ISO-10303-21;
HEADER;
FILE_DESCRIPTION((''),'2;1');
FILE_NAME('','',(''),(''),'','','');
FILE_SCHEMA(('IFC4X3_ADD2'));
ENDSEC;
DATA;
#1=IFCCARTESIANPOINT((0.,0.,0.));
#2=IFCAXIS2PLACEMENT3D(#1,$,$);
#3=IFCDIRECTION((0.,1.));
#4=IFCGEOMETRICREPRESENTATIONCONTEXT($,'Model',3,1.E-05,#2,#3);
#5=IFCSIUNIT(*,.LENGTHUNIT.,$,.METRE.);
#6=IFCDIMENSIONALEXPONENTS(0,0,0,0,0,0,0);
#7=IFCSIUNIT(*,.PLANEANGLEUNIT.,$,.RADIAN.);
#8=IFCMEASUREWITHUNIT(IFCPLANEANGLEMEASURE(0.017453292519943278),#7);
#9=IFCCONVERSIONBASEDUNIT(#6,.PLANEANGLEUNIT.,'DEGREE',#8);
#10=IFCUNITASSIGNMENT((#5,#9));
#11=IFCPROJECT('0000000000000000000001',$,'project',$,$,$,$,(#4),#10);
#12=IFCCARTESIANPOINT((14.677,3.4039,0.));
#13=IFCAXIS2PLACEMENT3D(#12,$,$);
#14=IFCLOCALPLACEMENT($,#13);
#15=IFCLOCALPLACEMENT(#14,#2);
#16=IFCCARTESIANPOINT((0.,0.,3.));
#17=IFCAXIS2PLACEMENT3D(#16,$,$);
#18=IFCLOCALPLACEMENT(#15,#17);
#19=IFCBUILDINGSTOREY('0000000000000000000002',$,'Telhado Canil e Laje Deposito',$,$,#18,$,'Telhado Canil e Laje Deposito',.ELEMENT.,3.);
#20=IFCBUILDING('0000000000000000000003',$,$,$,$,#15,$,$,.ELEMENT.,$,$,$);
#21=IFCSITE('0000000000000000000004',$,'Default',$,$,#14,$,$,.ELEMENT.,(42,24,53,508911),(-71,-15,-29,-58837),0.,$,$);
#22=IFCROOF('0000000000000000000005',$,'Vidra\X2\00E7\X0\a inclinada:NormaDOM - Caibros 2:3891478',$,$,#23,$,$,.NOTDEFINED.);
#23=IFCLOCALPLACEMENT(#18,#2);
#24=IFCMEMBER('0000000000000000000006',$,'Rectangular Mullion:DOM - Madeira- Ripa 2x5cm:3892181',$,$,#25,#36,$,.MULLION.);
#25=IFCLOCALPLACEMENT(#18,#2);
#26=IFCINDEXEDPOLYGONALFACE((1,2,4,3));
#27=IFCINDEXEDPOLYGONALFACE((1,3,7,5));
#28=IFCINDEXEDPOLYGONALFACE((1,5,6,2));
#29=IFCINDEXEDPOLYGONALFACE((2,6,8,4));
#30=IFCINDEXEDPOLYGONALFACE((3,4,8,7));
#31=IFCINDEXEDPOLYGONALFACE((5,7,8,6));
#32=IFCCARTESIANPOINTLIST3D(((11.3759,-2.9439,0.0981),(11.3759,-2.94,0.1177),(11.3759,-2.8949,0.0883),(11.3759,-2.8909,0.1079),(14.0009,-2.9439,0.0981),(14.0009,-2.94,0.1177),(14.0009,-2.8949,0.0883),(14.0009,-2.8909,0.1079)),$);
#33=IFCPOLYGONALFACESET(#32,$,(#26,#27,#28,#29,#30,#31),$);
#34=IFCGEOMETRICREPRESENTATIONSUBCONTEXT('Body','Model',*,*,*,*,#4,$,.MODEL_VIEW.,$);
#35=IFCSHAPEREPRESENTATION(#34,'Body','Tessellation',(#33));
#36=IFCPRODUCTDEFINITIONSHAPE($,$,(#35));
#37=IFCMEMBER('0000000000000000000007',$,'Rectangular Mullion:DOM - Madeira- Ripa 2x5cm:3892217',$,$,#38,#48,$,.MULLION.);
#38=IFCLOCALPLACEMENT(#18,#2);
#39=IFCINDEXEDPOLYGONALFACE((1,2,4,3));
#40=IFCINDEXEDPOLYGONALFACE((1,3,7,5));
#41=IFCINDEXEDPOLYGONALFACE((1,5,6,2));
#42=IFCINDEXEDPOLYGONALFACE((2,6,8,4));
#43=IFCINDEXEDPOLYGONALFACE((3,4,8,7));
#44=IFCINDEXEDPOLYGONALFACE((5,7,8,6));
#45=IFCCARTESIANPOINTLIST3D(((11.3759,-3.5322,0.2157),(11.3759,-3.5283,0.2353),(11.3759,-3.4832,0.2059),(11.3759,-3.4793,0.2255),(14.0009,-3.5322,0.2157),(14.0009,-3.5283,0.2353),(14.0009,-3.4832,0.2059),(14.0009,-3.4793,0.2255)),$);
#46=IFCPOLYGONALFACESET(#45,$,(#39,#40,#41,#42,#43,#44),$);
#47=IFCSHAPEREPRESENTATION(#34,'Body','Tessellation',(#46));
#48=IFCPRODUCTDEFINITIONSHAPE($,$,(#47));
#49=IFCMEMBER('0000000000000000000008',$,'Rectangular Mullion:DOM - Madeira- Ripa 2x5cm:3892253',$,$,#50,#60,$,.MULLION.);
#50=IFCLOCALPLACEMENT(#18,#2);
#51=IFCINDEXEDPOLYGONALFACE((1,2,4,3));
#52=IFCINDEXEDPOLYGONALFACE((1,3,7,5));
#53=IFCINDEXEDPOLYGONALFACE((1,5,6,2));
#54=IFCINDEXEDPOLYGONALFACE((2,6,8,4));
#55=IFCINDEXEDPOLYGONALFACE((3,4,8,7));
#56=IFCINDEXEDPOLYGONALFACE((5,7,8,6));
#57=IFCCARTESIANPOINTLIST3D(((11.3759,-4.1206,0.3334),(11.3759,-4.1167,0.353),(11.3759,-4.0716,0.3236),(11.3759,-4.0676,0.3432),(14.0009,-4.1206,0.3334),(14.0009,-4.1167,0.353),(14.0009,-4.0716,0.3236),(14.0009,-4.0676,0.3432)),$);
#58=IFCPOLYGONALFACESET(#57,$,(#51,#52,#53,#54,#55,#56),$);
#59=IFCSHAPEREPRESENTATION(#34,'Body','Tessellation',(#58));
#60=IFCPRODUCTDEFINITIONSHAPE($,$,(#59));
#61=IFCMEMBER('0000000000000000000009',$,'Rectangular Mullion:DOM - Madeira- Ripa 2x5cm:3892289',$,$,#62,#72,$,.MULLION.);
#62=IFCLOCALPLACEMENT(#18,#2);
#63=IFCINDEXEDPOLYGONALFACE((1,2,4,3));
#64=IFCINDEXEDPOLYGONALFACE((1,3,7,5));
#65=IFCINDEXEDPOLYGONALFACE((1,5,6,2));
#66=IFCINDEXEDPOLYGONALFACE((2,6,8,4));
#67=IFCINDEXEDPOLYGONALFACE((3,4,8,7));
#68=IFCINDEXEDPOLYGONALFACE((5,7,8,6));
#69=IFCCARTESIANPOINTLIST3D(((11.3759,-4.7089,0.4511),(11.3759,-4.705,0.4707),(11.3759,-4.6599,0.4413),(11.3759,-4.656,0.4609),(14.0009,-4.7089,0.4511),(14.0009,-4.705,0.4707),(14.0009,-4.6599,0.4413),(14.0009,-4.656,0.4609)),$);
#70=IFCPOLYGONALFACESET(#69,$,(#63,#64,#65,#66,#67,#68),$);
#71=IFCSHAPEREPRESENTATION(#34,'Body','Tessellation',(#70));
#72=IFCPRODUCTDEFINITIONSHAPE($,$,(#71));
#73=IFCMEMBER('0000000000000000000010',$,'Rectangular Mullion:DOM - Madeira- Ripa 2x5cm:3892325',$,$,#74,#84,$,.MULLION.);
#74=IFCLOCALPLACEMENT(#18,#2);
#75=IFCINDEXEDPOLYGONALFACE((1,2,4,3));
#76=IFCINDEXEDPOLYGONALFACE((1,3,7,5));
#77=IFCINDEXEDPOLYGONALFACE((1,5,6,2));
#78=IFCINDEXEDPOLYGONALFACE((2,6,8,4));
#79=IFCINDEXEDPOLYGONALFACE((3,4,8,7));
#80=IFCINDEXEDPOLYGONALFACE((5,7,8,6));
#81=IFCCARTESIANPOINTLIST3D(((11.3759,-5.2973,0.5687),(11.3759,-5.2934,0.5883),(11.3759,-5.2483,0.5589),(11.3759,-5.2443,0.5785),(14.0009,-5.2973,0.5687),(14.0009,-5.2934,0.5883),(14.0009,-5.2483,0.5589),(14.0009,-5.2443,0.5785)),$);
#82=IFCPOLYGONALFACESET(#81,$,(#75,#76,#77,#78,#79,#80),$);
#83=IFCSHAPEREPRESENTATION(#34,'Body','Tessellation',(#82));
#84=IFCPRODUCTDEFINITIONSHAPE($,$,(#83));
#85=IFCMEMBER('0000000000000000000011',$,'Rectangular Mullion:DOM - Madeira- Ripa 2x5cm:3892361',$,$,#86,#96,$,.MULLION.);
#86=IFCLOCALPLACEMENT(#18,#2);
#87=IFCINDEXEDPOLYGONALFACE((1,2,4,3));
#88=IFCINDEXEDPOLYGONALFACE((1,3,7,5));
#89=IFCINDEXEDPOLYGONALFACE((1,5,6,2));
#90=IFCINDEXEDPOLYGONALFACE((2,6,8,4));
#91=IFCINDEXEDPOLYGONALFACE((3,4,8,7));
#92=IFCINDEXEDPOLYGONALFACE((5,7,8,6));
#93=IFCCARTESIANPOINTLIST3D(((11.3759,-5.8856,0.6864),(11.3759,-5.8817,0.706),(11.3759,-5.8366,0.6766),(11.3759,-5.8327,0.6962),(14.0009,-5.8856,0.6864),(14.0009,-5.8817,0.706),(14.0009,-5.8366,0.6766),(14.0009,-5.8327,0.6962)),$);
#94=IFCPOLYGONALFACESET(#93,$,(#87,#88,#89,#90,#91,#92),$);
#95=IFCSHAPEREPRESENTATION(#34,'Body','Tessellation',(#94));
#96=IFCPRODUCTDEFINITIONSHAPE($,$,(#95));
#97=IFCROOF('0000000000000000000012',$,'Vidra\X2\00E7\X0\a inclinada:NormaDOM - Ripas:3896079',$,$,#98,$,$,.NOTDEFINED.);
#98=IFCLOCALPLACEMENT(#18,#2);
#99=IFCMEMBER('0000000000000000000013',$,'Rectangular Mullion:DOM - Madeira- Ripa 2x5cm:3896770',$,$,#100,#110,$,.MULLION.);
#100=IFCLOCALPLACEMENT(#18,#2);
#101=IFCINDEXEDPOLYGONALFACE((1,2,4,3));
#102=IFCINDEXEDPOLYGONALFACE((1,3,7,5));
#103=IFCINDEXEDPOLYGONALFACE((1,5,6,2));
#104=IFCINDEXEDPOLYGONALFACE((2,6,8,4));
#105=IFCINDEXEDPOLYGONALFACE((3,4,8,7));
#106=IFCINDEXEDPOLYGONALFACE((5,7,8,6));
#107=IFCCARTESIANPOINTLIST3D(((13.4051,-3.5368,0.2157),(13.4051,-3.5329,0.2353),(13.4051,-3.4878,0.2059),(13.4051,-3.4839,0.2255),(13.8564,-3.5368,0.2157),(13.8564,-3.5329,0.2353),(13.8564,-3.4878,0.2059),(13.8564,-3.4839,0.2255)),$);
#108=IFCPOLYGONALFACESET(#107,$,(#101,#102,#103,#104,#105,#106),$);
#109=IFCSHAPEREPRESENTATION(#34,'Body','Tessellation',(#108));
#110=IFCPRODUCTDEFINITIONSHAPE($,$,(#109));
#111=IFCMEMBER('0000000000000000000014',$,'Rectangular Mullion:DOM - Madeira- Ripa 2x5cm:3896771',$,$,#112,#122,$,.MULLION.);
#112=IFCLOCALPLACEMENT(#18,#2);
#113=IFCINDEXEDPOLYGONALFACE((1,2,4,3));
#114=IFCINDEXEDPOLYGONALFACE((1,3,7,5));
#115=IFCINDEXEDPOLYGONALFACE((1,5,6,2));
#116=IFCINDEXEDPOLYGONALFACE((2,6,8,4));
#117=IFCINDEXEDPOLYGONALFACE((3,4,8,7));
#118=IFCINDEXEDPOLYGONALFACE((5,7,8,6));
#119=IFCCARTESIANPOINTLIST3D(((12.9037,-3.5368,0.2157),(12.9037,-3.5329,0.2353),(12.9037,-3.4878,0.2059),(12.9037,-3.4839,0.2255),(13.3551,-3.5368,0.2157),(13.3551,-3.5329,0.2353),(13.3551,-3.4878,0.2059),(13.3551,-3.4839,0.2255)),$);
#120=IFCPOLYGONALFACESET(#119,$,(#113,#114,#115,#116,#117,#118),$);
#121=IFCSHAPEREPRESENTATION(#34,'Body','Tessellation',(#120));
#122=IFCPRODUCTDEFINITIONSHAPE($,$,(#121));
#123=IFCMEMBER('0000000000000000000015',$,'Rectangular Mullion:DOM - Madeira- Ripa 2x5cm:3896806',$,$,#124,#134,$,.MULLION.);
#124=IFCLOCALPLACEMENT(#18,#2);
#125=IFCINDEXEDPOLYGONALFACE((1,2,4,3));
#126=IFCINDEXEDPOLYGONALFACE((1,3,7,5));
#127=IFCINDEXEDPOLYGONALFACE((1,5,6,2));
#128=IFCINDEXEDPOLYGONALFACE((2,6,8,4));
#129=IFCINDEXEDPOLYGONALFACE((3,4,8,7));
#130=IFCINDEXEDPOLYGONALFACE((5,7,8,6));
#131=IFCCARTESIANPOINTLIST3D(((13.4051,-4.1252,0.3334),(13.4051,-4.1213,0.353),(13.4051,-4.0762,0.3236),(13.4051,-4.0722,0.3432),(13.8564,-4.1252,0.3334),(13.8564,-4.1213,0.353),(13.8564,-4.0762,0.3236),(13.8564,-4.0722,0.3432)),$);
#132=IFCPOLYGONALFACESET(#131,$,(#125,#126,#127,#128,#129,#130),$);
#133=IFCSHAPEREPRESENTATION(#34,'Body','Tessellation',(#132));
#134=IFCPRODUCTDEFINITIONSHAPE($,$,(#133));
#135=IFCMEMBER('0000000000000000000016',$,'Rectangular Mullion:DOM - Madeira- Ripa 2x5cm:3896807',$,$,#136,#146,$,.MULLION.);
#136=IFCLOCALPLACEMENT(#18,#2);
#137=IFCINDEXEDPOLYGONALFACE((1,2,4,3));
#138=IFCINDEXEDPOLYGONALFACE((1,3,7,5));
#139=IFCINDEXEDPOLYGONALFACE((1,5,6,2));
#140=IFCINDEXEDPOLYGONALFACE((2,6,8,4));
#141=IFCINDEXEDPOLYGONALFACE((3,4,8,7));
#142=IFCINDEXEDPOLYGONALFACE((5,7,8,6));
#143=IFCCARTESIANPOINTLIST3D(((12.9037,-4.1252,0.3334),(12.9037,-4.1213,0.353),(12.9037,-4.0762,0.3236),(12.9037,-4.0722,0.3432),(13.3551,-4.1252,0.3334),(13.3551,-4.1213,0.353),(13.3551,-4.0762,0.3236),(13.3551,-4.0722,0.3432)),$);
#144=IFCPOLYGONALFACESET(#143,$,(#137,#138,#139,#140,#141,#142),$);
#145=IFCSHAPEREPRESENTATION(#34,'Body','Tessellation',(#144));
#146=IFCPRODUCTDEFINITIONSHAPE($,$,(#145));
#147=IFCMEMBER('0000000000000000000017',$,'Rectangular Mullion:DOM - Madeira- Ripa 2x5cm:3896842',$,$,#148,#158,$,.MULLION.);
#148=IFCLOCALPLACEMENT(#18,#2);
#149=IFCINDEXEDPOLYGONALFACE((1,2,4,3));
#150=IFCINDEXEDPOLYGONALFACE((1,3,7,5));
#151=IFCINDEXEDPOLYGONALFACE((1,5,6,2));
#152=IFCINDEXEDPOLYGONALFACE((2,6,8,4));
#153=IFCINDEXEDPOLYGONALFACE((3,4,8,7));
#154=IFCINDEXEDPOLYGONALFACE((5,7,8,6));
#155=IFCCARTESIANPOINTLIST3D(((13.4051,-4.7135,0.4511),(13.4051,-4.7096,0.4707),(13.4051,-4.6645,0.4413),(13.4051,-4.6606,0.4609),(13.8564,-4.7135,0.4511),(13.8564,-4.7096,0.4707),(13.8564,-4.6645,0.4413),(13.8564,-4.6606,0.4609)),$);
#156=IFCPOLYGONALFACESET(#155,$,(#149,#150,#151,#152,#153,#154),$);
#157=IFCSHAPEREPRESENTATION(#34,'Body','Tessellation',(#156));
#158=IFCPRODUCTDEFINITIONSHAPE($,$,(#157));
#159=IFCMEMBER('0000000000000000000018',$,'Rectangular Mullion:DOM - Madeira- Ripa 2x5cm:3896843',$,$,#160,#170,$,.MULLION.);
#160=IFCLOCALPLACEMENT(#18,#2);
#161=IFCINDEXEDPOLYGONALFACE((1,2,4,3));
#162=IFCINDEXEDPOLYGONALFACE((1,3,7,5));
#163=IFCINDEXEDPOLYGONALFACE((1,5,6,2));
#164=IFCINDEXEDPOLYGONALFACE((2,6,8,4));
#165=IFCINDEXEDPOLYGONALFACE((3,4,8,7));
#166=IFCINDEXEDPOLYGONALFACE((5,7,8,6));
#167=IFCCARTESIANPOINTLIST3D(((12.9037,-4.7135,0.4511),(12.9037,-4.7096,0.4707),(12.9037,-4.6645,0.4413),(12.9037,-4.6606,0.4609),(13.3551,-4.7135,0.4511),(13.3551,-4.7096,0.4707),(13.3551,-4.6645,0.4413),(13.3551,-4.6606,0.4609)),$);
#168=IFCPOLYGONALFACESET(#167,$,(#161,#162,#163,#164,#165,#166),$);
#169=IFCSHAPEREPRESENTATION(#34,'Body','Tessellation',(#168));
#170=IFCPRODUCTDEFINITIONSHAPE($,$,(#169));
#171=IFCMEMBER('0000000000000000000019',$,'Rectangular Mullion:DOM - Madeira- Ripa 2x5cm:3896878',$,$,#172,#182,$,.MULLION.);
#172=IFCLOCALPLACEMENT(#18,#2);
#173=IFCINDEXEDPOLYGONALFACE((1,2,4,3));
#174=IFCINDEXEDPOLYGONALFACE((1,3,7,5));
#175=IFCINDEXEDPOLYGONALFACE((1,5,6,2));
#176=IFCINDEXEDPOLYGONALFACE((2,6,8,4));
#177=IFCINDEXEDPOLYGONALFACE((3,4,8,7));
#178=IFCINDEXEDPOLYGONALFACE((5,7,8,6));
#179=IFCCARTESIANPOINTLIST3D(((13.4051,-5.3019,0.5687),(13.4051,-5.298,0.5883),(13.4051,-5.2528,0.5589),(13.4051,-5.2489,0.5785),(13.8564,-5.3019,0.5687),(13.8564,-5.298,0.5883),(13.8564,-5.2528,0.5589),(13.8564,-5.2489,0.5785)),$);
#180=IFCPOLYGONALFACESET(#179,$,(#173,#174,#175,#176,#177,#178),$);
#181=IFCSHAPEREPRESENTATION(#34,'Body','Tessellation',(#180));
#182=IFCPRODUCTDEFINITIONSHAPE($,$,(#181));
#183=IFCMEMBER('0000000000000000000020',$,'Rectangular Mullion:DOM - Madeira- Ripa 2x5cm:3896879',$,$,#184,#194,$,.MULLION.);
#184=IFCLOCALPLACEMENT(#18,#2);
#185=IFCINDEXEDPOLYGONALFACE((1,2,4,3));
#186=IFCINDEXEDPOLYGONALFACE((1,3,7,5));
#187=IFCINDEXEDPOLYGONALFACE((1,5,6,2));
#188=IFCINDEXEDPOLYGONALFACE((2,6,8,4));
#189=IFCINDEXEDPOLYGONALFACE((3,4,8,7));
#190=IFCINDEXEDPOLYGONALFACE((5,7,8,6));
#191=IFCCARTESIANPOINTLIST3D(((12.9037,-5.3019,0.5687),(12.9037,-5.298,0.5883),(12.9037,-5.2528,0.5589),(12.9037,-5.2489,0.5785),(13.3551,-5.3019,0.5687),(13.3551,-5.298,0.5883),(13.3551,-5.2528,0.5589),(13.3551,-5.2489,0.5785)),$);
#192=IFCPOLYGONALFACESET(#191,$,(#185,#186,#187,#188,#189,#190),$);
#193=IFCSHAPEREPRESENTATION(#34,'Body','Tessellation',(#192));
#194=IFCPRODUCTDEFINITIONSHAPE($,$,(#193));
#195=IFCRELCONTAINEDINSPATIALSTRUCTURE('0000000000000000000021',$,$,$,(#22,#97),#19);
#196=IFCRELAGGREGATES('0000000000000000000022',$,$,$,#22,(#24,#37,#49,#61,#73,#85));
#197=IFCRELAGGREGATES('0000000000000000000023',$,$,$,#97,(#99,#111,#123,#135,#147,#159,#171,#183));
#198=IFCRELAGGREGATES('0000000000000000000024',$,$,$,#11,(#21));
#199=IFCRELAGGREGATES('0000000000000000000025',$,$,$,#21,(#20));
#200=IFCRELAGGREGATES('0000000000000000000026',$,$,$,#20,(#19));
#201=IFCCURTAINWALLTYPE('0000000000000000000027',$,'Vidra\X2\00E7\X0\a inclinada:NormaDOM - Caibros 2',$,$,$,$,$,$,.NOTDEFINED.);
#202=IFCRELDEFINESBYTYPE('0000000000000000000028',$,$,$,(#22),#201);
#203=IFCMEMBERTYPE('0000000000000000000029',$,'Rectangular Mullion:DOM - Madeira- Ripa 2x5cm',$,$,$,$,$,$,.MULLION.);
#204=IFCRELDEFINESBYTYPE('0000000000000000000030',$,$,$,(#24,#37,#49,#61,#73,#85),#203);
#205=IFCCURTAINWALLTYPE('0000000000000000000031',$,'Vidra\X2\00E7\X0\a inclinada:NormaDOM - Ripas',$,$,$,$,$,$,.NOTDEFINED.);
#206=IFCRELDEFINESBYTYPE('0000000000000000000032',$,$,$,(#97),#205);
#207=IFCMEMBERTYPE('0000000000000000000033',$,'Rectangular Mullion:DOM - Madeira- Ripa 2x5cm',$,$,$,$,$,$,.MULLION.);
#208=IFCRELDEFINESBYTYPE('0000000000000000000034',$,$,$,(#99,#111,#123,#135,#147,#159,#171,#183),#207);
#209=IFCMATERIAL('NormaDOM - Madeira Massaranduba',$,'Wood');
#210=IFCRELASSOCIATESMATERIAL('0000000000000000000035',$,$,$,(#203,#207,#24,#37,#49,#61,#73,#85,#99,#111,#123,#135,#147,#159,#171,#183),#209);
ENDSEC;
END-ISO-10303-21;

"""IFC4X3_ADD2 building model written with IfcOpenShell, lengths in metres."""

from ifc_helpers import new_model, entity, si_unit, converted_unit, direction, frame, origin, origin_2d_with_axis, place, context, subcontext, project, spatial, rectangle, extrude, source, transform, mapped, material, material_profile, profile_set, profile_usage, type_object, type_shapes, element, aggregate, save


model = new_model("IFC4X3_ADD2")

# Units and contexts
model_context = context("Model", 3, precision=1e-05, world=origin(), true_north=direction((0.0, 1.0)))
body_context = subcontext(model_context, "Body", "Model", "MODEL_VIEW")
ifc_project = project(units=[si_unit("LENGTHUNIT", "METRE"), converted_unit("PLANEANGLEUNIT", "DEGREE", entity("IfcPlaneAngleMeasure", 0.017453292519943278), si_unit("PLANEANGLEUNIT", "RADIAN"), dimensions=[0, 0, 0, 0, 0, 0, 0])], contexts=[model_context])

# Site, building, storey
site_placement = place(None, frame((14.677, 3.4039, 0.0)))
site = spatial("IfcSite", under=ifc_project, at=site_placement, Name="Default", CompositionType="ELEMENT", RefLatitude=(42, 24, 53, 508911), RefLongitude=(-71, -15, -29, -58837), RefElevation=0.0)
building_placement = place(site_placement, origin())
building = spatial("IfcBuilding", under=site, at=building_placement, CompositionType="ELEMENT")
storey_placement = place(building_placement, frame((0.0, 0.0, 3.0)))
storey = spatial("IfcBuildingStorey", under=building, at=storey_placement, Name="Telhado Canil e Laje Deposito", LongName="Telhado Canil e Laje Deposito", CompositionType="ELEMENT", Elevation=3.0)

# Roofs, members
curtain_wall_type_1 = type_object("IfcCurtainWallType", Name="Vidraça inclinada:NormaDOM - Caibros 2", PredefinedType="NOTDEFINED")
roof_1_placement = place(storey_placement, frame((0.0, 0.0, -3.0)))
roof_1 = element("IfcRoof", 1, at=roof_1_placement, inside=storey, type_object=curtain_wall_type_1, Name="Vidraça inclinada:NormaDOM - Caibros 2:3891478", PredefinedType="NOTDEFINED")
ifc_material = material(Name="NormaDOM - Madeira Massaranduba", Category="Wood")
ifc_material_profile_1 = material_profile(ifc_material, rectangle(XDim=0.05, YDim=0.02, at=origin_2d_with_axis()), Name="DOM - Madeira- Ripa 2x5cm")
ifc_profile_set_1 = profile_set([ifc_material_profile_1], Name="DOM - Madeira- Ripa 2x5cm")
ifc_profile_usage_1 = profile_usage(ifc_profile_set_1)
member_type_1 = type_object("IfcMemberType", Name="Rectangular Mullion:DOM - Madeira- Ripa 2x5cm", PredefinedType="MULLION", material=ifc_profile_set_1)
shared_shape_1 = source(origin(), body_context, "Body", "SweptSolid", [
    extrude(rectangle(XDim=0.05, YDim=0.02, at=origin_2d_with_axis()), frame((0.025, 0.01, -2.625), z_axis=(0.0, 0.0, 1.0), x_axis=(-1.0, 0.0, 0.0)), (0.0, 0.0, 1.0), 2.625),
])
type_shapes(member_type_1, [shared_shape_1])
member_1_placement = place(roof_1_placement, frame((14.0009, -2.8909, 3.1079), z_axis=(1.0, 0.0, 0.0), x_axis=(0.0, -0.980581, 0.196116)))
member_1 = element("IfcMember", 2, at=member_1_placement, type_object=member_type_1, material=ifc_profile_usage_1, Name="Rectangular Mullion:DOM - Madeira- Ripa 2x5cm:3892181", PredefinedType="MULLION", context=body_context, shape_type="MappedRepresentation", body=[
    mapped(shared_shape_1, transform((0.0, 0.0, 0.0), scale=1.0)),
])
member_2_placement = place(roof_1_placement, frame((14.0009, -3.4793, 3.2255), z_axis=(1.0, 0.0, 0.0), x_axis=(0.0, -0.980581, 0.196116)))
member_2 = element("IfcMember", 3, at=member_2_placement, type_object=member_type_1, material=ifc_profile_usage_1, Name="Rectangular Mullion:DOM - Madeira- Ripa 2x5cm:3892217", PredefinedType="MULLION", context=body_context, shape_type="MappedRepresentation", body=[
    mapped(shared_shape_1, transform((0.0, 0.0, 0.0), scale=1.0)),
])
member_3_placement = place(roof_1_placement, frame((14.0009, -4.0676, 3.3432), z_axis=(1.0, 0.0, 0.0), x_axis=(0.0, -0.980581, 0.196116)))
member_3 = element("IfcMember", 4, at=member_3_placement, type_object=member_type_1, material=ifc_profile_usage_1, Name="Rectangular Mullion:DOM - Madeira- Ripa 2x5cm:3892253", PredefinedType="MULLION", context=body_context, shape_type="MappedRepresentation", body=[
    mapped(shared_shape_1, transform((0.0, 0.0, 0.0), scale=1.0)),
])
member_4_placement = place(roof_1_placement, frame((14.0009, -4.656, 3.4609), z_axis=(1.0, 0.0, 0.0), x_axis=(0.0, -0.980581, 0.196116)))
member_4 = element("IfcMember", 5, at=member_4_placement, type_object=member_type_1, material=ifc_profile_usage_1, Name="Rectangular Mullion:DOM - Madeira- Ripa 2x5cm:3892289", PredefinedType="MULLION", context=body_context, shape_type="MappedRepresentation", body=[
    mapped(shared_shape_1, transform((0.0, 0.0, 0.0), scale=1.0)),
])
member_5_placement = place(roof_1_placement, frame((14.0009, -5.2443, 3.5785), z_axis=(1.0, 0.0, 0.0), x_axis=(0.0, -0.980581, 0.196116)))
member_5 = element("IfcMember", 6, at=member_5_placement, type_object=member_type_1, material=ifc_profile_usage_1, Name="Rectangular Mullion:DOM - Madeira- Ripa 2x5cm:3892325", PredefinedType="MULLION", context=body_context, shape_type="MappedRepresentation", body=[
    mapped(shared_shape_1, transform((0.0, 0.0, 0.0), scale=1.0)),
])
member_6_placement = place(roof_1_placement, frame((14.0009, -5.8327, 3.6962), z_axis=(1.0, 0.0, 0.0), x_axis=(0.0, -0.980581, 0.196116)))
member_6 = element("IfcMember", 7, at=member_6_placement, type_object=member_type_1, material=ifc_profile_usage_1, Name="Rectangular Mullion:DOM - Madeira- Ripa 2x5cm:3892361", PredefinedType="MULLION", context=body_context, shape_type="MappedRepresentation", body=[
    mapped(shared_shape_1, transform((0.0, 0.0, 0.0), scale=1.0)),
])
curtain_wall_type_2 = type_object("IfcCurtainWallType", Name="Vidraça inclinada:NormaDOM - Ripas", PredefinedType="NOTDEFINED")
roof_2_placement = place(storey_placement, frame((0.0, 0.0, -3.0)))
roof_2 = element("IfcRoof", 8, at=roof_2_placement, inside=storey, type_object=curtain_wall_type_2, Name="Vidraça inclinada:NormaDOM - Ripas:3896079", PredefinedType="NOTDEFINED")

# Members
aggregate(roof_1, [member_1, member_2, member_3, member_4, member_5, member_6])
member_type_2 = type_object("IfcMemberType", Name="Rectangular Mullion:DOM - Madeira- Ripa 2x5cm", PredefinedType="MULLION", material=ifc_profile_set_1)
shared_shape_2 = source(origin(), body_context, "Body", "SweptSolid", [
    extrude(rectangle(XDim=0.05, YDim=0.02, at=origin_2d_with_axis()), frame((0.025, 0.01, -0.4514), z_axis=(0.0, 0.0, 1.0), x_axis=(-1.0, 0.0, 0.0)), (0.0, 0.0, 1.0), 0.4514),
])
type_shapes(member_type_2, [shared_shape_2])
member_7_placement = place(roof_2_placement, frame((13.8564, -3.4839, 3.2255), z_axis=(1.0, 0.0, 0.0), x_axis=(0.0, -0.980581, 0.196116)))
member_7 = element("IfcMember", 9, at=member_7_placement, type_object=member_type_2, material=ifc_profile_usage_1, Name="Rectangular Mullion:DOM - Madeira- Ripa 2x5cm:3896770", PredefinedType="MULLION", context=body_context, shape_type="MappedRepresentation", body=[
    mapped(shared_shape_2, transform((0.0, 0.0, 0.0), scale=1.0)),
])
member_8_placement = place(roof_2_placement, frame((13.3551, -3.4839, 3.2255), z_axis=(1.0, 0.0, 0.0), x_axis=(0.0, -0.980581, 0.196116)))
member_8 = element("IfcMember", 10, at=member_8_placement, type_object=member_type_2, material=ifc_profile_usage_1, Name="Rectangular Mullion:DOM - Madeira- Ripa 2x5cm:3896771", PredefinedType="MULLION", context=body_context, shape_type="MappedRepresentation", body=[
    mapped(shared_shape_2, transform((0.0, 0.0, 0.0), scale=1.0)),
])
member_9_placement = place(roof_2_placement, frame((13.8564, -4.0722, 3.3432), z_axis=(1.0, 0.0, 0.0), x_axis=(0.0, -0.980581, 0.196116)))
member_9 = element("IfcMember", 11, at=member_9_placement, type_object=member_type_2, material=ifc_profile_usage_1, Name="Rectangular Mullion:DOM - Madeira- Ripa 2x5cm:3896806", PredefinedType="MULLION", context=body_context, shape_type="MappedRepresentation", body=[
    mapped(shared_shape_2, transform((0.0, 0.0, 0.0), scale=1.0)),
])
member_10_placement = place(roof_2_placement, frame((13.3551, -4.0722, 3.3432), z_axis=(1.0, 0.0, 0.0), x_axis=(0.0, -0.980581, 0.196116)))
member_10 = element("IfcMember", 12, at=member_10_placement, type_object=member_type_2, material=ifc_profile_usage_1, Name="Rectangular Mullion:DOM - Madeira- Ripa 2x5cm:3896807", PredefinedType="MULLION", context=body_context, shape_type="MappedRepresentation", body=[
    mapped(shared_shape_2, transform((0.0, 0.0, 0.0), scale=1.0)),
])
member_11_placement = place(roof_2_placement, frame((13.8564, -4.6606, 3.4609), z_axis=(1.0, 0.0, 0.0), x_axis=(0.0, -0.980581, 0.196116)))
member_11 = element("IfcMember", 13, at=member_11_placement, type_object=member_type_2, material=ifc_profile_usage_1, Name="Rectangular Mullion:DOM - Madeira- Ripa 2x5cm:3896842", PredefinedType="MULLION", context=body_context, shape_type="MappedRepresentation", body=[
    mapped(shared_shape_2, transform((0.0, 0.0, 0.0), scale=1.0)),
])
member_12_placement = place(roof_2_placement, frame((13.3551, -4.6606, 3.4609), z_axis=(1.0, 0.0, 0.0), x_axis=(0.0, -0.980581, 0.196116)))
member_12 = element("IfcMember", 14, at=member_12_placement, type_object=member_type_2, material=ifc_profile_usage_1, Name="Rectangular Mullion:DOM - Madeira- Ripa 2x5cm:3896843", PredefinedType="MULLION", context=body_context, shape_type="MappedRepresentation", body=[
    mapped(shared_shape_2, transform((0.0, 0.0, 0.0), scale=1.0)),
])
member_13_placement = place(roof_2_placement, frame((13.8564, -5.2489, 3.5785), z_axis=(1.0, 0.0, 0.0), x_axis=(0.0, -0.980581, 0.196116)))
member_13 = element("IfcMember", 15, at=member_13_placement, type_object=member_type_2, material=ifc_profile_usage_1, Name="Rectangular Mullion:DOM - Madeira- Ripa 2x5cm:3896878", PredefinedType="MULLION", context=body_context, shape_type="MappedRepresentation", body=[
    mapped(shared_shape_2, transform((0.0, 0.0, 0.0), scale=1.0)),
])
member_14_placement = place(roof_2_placement, frame((13.3551, -5.2489, 3.5785), z_axis=(1.0, 0.0, 0.0), x_axis=(0.0, -0.980581, 0.196116)))
member_14 = element("IfcMember", 16, at=member_14_placement, type_object=member_type_2, material=ifc_profile_usage_1, Name="Rectangular Mullion:DOM - Madeira- Ripa 2x5cm:3896879", PredefinedType="MULLION", context=body_context, shape_type="MappedRepresentation", body=[
    mapped(shared_shape_2, transform((0.0, 0.0, 0.0), scale=1.0)),
])
aggregate(roof_2, [member_7, member_8, member_9, member_10, member_11, member_12, member_13, member_14])

save(model, "model.ifc")
